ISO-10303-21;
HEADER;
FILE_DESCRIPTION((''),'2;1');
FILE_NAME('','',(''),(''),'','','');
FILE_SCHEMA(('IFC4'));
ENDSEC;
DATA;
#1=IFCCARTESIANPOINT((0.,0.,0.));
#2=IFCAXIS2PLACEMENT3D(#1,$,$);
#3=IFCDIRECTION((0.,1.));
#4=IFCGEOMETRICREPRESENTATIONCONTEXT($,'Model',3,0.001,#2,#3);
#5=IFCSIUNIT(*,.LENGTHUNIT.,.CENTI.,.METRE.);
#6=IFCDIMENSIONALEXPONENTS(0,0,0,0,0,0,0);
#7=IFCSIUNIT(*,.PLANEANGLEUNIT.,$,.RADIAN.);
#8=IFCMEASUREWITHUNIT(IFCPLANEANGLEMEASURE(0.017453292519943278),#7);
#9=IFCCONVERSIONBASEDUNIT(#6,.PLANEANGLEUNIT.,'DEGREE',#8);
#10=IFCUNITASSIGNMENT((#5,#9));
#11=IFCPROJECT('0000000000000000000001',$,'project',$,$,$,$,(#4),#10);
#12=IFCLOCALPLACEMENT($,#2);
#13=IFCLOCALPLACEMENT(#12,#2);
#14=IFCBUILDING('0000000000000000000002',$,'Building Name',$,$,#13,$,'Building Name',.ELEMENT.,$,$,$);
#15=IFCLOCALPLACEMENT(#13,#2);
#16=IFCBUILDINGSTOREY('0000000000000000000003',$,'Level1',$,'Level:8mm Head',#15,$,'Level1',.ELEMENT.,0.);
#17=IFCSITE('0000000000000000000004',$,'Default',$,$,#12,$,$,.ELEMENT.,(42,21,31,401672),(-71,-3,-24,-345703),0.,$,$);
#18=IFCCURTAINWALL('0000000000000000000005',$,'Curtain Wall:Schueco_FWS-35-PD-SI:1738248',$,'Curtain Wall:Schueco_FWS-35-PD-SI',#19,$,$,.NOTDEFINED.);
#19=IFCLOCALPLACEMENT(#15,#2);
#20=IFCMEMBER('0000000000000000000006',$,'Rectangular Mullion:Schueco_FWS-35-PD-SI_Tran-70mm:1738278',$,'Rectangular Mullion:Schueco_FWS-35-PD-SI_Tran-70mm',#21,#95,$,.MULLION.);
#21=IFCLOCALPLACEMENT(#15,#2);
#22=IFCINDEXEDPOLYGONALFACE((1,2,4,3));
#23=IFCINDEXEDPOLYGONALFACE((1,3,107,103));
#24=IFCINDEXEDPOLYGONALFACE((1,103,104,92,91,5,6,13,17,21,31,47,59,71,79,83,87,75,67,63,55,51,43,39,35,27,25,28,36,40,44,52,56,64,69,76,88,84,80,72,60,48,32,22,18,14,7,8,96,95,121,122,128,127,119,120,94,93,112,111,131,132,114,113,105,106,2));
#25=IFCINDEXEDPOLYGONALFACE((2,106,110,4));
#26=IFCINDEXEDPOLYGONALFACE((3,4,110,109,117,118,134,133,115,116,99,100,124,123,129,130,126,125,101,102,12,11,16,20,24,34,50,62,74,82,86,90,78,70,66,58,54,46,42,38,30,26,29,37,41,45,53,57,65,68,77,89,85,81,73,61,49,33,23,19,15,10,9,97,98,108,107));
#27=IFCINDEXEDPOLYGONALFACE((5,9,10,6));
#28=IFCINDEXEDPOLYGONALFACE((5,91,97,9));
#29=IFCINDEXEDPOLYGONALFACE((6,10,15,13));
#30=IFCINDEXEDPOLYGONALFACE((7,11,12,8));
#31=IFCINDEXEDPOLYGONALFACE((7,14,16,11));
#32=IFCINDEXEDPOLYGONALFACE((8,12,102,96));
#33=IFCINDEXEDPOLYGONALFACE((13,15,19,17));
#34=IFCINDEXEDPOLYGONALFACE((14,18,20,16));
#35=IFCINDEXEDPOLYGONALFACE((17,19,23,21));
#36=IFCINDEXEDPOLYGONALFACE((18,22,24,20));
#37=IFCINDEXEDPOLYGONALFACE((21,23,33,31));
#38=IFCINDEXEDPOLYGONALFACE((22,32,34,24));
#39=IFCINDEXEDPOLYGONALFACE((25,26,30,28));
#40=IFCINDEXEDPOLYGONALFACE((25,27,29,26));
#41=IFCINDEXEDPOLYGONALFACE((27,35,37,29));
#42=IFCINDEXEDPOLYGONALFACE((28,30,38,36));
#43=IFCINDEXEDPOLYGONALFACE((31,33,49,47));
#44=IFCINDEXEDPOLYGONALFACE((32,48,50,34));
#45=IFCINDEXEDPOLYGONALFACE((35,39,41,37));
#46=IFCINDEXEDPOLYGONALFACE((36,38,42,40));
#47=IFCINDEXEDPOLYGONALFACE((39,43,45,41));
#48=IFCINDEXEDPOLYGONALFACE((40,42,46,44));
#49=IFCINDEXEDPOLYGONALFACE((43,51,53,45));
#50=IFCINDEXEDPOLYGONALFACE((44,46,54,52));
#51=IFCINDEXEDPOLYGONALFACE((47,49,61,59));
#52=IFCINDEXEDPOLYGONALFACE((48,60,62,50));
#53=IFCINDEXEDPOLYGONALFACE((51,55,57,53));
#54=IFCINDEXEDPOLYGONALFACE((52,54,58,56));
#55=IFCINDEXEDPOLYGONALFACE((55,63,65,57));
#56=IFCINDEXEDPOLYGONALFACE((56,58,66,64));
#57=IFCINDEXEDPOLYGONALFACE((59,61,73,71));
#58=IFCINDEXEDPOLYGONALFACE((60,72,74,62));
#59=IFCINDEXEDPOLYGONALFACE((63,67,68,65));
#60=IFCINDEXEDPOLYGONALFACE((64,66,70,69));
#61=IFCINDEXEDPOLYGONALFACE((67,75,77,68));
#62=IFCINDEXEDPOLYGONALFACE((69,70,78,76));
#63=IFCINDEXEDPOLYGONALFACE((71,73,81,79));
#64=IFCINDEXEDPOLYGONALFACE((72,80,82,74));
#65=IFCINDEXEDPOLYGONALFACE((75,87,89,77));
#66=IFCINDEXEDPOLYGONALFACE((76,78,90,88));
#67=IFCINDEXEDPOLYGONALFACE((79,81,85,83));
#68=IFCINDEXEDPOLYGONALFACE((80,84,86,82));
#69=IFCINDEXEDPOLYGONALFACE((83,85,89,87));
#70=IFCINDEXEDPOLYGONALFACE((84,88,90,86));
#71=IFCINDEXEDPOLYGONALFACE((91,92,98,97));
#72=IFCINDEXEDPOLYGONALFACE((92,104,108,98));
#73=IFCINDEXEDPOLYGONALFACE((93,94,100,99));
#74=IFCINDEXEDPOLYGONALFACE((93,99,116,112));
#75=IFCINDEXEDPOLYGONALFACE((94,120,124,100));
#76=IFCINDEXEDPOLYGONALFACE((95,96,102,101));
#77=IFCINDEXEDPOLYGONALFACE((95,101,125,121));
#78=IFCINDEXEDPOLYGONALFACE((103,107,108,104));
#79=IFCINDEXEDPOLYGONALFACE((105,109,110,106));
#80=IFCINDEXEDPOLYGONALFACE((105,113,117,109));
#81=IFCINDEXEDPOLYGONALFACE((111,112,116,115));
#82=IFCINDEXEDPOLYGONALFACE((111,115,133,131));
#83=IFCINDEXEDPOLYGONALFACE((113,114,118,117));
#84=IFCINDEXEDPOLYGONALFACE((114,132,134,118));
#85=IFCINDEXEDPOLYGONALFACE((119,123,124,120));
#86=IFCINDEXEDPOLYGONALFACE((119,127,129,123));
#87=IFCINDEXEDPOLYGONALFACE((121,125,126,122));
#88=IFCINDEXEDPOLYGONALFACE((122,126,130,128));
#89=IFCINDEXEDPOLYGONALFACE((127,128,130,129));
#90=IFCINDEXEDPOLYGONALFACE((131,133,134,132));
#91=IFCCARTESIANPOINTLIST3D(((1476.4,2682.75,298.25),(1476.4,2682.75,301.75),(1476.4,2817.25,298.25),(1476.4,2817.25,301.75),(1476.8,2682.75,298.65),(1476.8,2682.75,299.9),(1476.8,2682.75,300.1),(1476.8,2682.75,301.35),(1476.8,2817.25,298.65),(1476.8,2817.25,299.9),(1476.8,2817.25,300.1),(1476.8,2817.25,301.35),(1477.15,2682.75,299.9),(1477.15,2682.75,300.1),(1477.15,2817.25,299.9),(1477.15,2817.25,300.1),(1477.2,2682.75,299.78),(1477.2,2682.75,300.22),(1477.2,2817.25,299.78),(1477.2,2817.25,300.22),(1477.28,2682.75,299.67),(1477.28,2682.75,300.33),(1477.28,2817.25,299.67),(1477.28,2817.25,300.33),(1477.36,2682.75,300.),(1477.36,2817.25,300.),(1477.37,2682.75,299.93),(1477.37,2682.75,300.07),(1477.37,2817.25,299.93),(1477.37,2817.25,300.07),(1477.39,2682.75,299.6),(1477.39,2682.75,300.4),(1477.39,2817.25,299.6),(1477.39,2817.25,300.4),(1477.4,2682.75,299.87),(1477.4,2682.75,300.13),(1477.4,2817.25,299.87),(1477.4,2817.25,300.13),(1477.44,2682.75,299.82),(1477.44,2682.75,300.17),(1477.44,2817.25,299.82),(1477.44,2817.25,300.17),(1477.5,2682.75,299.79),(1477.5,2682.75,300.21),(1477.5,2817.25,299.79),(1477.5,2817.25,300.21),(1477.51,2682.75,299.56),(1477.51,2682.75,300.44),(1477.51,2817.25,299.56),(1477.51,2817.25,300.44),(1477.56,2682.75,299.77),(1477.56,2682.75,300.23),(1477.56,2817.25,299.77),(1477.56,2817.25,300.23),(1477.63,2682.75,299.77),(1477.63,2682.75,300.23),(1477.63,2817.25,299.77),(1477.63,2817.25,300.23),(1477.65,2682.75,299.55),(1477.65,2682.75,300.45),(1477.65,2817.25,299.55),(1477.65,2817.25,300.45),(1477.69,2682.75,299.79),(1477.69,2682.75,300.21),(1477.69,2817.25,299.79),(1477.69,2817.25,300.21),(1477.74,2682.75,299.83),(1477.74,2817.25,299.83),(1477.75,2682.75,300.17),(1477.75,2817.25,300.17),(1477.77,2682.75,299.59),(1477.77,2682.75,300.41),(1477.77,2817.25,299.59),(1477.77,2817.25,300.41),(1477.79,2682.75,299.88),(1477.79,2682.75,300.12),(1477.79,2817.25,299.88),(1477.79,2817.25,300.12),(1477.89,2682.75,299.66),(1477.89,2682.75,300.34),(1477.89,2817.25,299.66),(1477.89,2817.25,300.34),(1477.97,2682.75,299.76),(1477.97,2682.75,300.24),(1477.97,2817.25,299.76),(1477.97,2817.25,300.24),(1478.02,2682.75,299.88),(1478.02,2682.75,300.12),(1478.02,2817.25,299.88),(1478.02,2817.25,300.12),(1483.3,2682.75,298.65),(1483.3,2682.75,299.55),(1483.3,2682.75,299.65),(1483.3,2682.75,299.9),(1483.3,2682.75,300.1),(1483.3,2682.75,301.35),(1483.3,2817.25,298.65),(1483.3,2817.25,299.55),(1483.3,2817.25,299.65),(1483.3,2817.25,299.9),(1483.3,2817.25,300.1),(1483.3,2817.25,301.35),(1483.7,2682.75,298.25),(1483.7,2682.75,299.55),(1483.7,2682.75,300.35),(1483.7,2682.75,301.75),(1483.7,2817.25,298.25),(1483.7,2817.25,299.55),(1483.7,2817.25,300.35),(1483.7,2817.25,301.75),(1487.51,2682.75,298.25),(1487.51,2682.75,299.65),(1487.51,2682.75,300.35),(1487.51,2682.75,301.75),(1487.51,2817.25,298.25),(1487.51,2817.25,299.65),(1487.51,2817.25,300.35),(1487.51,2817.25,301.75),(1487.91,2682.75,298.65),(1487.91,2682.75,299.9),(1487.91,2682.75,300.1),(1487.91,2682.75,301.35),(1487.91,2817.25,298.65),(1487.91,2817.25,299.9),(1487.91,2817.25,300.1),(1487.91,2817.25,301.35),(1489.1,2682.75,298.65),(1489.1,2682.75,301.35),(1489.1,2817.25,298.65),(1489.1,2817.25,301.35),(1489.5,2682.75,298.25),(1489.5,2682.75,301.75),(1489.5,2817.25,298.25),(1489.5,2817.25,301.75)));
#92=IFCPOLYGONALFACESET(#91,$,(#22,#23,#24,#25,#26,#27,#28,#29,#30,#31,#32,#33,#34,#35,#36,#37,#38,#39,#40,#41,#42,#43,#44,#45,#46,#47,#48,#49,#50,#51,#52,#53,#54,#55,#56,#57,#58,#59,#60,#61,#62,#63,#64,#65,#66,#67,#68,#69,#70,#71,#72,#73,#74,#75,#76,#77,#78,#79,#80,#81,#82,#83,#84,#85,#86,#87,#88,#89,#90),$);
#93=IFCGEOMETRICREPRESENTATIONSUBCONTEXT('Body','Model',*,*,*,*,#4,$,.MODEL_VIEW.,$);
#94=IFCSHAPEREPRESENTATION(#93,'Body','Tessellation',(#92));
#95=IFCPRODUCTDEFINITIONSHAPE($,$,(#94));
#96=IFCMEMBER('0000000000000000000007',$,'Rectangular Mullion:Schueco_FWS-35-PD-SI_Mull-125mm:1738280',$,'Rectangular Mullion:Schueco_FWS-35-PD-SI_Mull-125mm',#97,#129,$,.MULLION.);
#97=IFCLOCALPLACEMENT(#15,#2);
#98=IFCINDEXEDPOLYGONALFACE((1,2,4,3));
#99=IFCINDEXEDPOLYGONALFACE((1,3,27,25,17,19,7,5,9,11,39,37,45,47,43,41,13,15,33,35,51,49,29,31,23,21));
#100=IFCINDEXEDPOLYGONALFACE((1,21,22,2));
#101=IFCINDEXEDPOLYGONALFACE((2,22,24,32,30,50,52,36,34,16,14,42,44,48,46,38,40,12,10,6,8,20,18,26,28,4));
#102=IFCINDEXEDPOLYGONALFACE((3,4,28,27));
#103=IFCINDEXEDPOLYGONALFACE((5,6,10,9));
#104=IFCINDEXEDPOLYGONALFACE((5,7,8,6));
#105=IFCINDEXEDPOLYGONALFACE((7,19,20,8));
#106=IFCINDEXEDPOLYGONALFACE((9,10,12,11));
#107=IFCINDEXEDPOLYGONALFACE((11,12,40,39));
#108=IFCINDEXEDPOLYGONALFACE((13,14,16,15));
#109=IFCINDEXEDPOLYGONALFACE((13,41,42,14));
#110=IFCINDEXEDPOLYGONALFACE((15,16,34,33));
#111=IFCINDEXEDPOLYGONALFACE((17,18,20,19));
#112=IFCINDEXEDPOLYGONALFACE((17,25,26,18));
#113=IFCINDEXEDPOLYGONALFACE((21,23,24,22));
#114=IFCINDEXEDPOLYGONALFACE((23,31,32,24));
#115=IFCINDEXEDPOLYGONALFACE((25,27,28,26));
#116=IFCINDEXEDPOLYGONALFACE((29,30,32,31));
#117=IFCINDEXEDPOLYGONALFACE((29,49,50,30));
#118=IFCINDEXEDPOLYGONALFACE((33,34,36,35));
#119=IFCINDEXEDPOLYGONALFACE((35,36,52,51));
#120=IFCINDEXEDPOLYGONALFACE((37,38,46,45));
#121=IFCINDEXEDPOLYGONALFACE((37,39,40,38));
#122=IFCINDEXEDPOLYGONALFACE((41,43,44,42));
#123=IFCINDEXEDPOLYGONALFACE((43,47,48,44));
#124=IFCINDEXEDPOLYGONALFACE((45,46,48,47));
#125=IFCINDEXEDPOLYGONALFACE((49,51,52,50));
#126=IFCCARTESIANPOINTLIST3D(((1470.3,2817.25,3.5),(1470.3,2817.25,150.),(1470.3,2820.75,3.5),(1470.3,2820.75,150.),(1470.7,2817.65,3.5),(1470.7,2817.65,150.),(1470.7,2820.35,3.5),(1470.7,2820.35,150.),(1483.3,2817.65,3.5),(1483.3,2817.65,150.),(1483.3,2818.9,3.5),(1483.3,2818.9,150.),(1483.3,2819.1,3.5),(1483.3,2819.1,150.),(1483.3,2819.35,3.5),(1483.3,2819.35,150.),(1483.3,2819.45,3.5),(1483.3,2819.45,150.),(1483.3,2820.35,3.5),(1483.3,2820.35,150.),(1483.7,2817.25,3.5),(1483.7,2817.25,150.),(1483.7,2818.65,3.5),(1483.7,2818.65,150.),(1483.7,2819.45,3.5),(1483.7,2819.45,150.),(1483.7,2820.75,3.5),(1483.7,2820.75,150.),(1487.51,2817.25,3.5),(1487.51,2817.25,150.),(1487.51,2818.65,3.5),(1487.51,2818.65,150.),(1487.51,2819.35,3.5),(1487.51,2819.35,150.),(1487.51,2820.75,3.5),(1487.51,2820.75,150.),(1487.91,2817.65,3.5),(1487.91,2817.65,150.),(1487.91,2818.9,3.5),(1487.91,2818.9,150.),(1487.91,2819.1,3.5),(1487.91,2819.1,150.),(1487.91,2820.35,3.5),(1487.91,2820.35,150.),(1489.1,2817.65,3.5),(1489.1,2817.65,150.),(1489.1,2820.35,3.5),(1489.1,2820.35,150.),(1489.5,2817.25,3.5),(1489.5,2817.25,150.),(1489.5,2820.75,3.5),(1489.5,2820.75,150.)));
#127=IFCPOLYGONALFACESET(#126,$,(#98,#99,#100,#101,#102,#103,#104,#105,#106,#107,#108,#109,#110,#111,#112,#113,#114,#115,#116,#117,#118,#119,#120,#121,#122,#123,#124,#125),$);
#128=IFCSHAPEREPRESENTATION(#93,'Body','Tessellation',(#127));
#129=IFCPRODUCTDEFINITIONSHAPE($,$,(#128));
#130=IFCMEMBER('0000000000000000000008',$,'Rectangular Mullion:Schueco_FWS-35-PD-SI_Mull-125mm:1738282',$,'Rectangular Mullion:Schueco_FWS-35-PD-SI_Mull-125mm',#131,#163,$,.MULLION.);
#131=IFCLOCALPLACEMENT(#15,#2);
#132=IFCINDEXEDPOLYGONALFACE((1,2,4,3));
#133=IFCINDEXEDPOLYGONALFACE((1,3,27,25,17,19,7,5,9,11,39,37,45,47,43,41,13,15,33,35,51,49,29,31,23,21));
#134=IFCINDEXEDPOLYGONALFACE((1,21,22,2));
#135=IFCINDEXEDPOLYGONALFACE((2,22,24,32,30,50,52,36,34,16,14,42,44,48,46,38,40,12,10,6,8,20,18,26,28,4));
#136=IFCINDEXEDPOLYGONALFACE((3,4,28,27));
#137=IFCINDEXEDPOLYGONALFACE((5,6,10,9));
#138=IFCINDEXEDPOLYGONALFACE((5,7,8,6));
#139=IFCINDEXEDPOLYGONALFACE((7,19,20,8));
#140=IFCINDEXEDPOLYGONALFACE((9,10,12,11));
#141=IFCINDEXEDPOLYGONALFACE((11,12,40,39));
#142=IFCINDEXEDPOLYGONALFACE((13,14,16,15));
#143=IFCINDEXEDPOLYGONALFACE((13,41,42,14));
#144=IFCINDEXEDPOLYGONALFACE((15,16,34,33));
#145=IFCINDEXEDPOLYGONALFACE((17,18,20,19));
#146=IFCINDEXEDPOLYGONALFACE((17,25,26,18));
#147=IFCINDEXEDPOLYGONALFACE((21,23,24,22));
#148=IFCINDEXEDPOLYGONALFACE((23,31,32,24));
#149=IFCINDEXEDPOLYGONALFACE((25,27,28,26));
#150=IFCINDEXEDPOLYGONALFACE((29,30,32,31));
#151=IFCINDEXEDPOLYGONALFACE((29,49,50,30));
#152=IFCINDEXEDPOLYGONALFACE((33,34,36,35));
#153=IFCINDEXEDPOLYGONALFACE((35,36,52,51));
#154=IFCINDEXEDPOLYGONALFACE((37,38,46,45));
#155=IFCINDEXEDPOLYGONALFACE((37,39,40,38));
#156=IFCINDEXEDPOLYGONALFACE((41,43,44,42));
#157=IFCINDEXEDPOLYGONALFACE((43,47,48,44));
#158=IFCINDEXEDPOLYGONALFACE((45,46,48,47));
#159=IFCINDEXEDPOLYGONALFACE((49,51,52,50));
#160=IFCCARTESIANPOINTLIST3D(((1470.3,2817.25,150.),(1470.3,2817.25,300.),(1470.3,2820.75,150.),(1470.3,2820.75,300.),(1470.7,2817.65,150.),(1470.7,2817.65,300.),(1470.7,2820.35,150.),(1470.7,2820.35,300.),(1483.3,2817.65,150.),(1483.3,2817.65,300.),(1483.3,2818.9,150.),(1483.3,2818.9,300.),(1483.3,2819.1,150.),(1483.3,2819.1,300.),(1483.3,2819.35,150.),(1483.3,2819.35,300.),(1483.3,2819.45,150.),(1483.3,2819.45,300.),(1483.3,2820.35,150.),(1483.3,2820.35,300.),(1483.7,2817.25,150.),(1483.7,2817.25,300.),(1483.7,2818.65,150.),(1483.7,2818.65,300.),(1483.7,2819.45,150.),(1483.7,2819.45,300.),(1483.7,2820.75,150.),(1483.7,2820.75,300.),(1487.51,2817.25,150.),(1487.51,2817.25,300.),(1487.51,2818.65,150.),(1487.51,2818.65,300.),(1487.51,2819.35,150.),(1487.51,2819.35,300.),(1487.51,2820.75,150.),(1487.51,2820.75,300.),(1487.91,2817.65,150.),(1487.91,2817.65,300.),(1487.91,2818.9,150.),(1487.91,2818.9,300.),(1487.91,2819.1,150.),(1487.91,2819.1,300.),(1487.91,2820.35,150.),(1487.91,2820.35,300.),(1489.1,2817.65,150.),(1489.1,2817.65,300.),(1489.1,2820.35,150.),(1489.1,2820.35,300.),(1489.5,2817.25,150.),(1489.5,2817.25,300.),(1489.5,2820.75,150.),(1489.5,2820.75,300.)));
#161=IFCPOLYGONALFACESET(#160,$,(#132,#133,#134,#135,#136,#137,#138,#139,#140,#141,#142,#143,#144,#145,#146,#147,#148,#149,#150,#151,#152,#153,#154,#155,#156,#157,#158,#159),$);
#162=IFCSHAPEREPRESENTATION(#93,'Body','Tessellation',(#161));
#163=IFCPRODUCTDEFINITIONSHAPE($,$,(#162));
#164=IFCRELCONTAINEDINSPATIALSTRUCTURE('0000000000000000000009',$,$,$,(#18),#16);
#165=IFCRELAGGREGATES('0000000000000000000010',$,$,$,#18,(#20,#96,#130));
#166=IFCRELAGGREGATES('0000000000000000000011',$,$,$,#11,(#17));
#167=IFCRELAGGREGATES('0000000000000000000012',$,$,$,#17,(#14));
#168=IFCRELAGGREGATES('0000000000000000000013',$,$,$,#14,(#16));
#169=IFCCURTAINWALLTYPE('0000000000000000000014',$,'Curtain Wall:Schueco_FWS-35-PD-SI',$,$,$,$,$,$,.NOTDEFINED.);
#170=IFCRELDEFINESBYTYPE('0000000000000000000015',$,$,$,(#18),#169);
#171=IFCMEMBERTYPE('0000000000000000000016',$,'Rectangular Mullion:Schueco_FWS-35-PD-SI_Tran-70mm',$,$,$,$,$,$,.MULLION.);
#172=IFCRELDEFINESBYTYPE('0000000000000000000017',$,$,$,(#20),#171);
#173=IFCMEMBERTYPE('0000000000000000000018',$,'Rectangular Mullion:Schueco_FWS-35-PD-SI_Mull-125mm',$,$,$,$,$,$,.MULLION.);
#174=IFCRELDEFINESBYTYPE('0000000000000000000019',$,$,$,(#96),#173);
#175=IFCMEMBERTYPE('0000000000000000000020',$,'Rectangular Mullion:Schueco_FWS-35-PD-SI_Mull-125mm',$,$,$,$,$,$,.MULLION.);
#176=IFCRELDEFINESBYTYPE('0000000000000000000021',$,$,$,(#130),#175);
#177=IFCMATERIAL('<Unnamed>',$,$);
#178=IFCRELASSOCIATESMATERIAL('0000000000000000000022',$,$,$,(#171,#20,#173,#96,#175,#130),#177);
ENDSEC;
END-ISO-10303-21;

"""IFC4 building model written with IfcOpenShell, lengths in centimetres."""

from ifc_helpers import new_model, entity, si_unit, converted_unit, direction, frame, origin, place, context, subcontext, project, spatial, line, arc, indexed_curve, outline, extrude, source, transform, mapped, material, type_object, type_shapes, element, aggregate, save


model = new_model("IFC4")

# Units and contexts
model_context = context("Model", 3, precision=0.001, world=origin(), true_north=direction((0.0, 1.0)))
body_context = subcontext(model_context, "Body", "Model", "MODEL_VIEW")
ifc_project = project(units=[si_unit("LENGTHUNIT", "METRE", prefix="CENTI"), converted_unit("PLANEANGLEUNIT", "DEGREE", entity("IfcPlaneAngleMeasure", 0.017453292519943278), si_unit("PLANEANGLEUNIT", "RADIAN"), dimensions=[0, 0, 0, 0, 0, 0, 0])], contexts=[model_context])

# Site, building, storey
site_placement = place(None, origin())
site = spatial("IfcSite", under=ifc_project, at=site_placement, Name="Default", CompositionType="ELEMENT", RefLatitude=(42, 21, 31, 401672), RefLongitude=(-71, -3, -24, -345703), RefElevation=0.0)
building_placement = place(site_placement, origin())
building = spatial("IfcBuilding", under=site, at=building_placement, Name="Building Name", LongName="Building Name", CompositionType="ELEMENT")
storey_placement = place(building_placement, origin())
storey = spatial("IfcBuildingStorey", under=building, at=storey_placement, Name="Level1", ObjectType="Level:8mm Head", LongName="Level1", CompositionType="ELEMENT", Elevation=0.0)

# Curtain wall, members
curtain_wall_type = type_object("IfcCurtainWallType", Name="Curtain Wall:Schueco_FWS-35-PD-SI", PredefinedType="NOTDEFINED")
curtain_wall_placement = place(storey_placement, origin())
curtain_wall = element("IfcCurtainWall", 1, at=curtain_wall_placement, inside=storey, type_object=curtain_wall_type, Name="Curtain Wall:Schueco_FWS-35-PD-SI:1738248", ObjectType="Curtain Wall:Schueco_FWS-35-PD-SI", PredefinedType="NOTDEFINED")
ifc_material_1 = material(Name="<Unnamed>")
member_type_1 = type_object("IfcMemberType", Name="Rectangular Mullion:Schueco_FWS-35-PD-SI_Tran-70mm", PredefinedType="MULLION", material=ifc_material_1)
shared_shape_1 = source(origin(), body_context, "Body", "SweptSolid", [
    extrude(outline(indexed_curve([(-1.78, -6.52), (1.72, -6.52), (1.72, 0.78), (0.42, 0.78), (0.42, 0.38), (1.32, 0.38), (1.32, -6.12), (0.07, -6.12), (0.07, -5.77), (0.42, -5.34), (0.09, -4.9), (0.09, -5.14), (-0.03, -5.56), (-0.15, -5.14), (-0.15, -4.9), (-0.48, -5.34), (-0.13, -5.77), (-0.13, -6.12), (-1.38, -6.12), (-1.38, 0.38), (-0.13, 0.38), (-0.13, 4.99), (-1.38, 4.99), (-1.38, 6.18), (1.32, 6.18), (1.32, 4.99), (0.07, 4.99), (0.07, 0.38), (0.32, 0.38), (0.32, 4.59), (1.72, 4.59), (1.72, 6.58), (-1.78, 6.58), (-1.78, 4.59), (-0.38, 4.59), (-0.38, 0.78), (-1.78, 0.78)], segments=[line(1, 2, 3, 4, 5, 6, 7, 8, 9), arc(9, 10, 11), line(11, 12), arc(12, 13, 14), line(14, 15), arc(15, 16, 17), line(17, 18, 19, 20, 21, 22, 23, 24, 25, 26, 27, 28, 29, 30, 31, 32, 33, 34, 35, 36, 37, 1)], self_intersect=False)), frame((-0.03, 4.58, -134.5), z_axis=(0.0, 0.0, 1.0), x_axis=(-1.0, 0.0, 0.0)), (0.0, 0.0, 1.0), 134.5),
])
type_shapes(member_type_1, [shared_shape_1])
member_1_placement = place(curtain_wall_placement, frame((1487.5, 2682.75, 300.0), z_axis=(0.0, -1.0, 0.0), x_axis=(0.0, 0.0, 1.0)))
member_1 = element("IfcMember", 2, at=member_1_placement, type_object=member_type_1, material=ifc_material_1, Name="Rectangular Mullion:Schueco_FWS-35-PD-SI_Tran-70mm:1738278", ObjectType="Rectangular Mullion:Schueco_FWS-35-PD-SI_Tran-70mm", PredefinedType="MULLION", context=body_context, shape_type="MappedRepresentation", body=[
    mapped(shared_shape_1, transform((0.0, 0.0, 0.0), scale=1.0)),
])
member_type_2 = type_object("IfcMemberType", Name="Rectangular Mullion:Schueco_FWS-35-PD-SI_Mull-125mm", PredefinedType="MULLION", material=ifc_material_1)
shared_shape_2 = source(origin(), body_context, "Body", "SweptSolid", [
    extrude(outline(indexed_curve([(-1.78, -13.37), (1.72, -13.37), (1.72, 0.03), (0.42, 0.03), (0.42, -0.37), (1.32, -0.37), (1.32, -12.97), (-1.38, -12.97), (-1.38, -0.37), (-0.13, -0.37), (-0.13, 4.24), (-1.38, 4.24), (-1.38, 5.43), (1.32, 5.43), (1.32, 4.24), (0.07, 4.24), (0.07, -0.37), (0.32, -0.37), (0.32, 3.84), (1.72, 3.84), (1.72, 5.83), (-1.78, 5.83), (-1.78, 3.84), (-0.38, 3.84), (-0.38, 0.03), (-1.78, 0.03), (-1.78, -13.37)], self_intersect=False)), frame((-0.03, 3.83, -146.5), z_axis=(0.0, 0.0, 1.0), x_axis=(-1.0, 0.0, 0.0)), (0.0, 0.0, 1.0), 146.5),
])
type_shapes(member_type_2, [shared_shape_2])
member_2_placement = place(curtain_wall_placement, frame((1487.5, 2819.0, 3.5), z_axis=(0.0, 0.0, -1.0), x_axis=(0.0, -1.0, 0.0)))
member_2 = element("IfcMember", 3, at=member_2_placement, type_object=member_type_2, material=ifc_material_1, Name="Rectangular Mullion:Schueco_FWS-35-PD-SI_Mull-125mm:1738280", ObjectType="Rectangular Mullion:Schueco_FWS-35-PD-SI_Mull-125mm", PredefinedType="MULLION", context=body_context, shape_type="MappedRepresentation", body=[
    mapped(shared_shape_2, transform((0.0, 0.0, 0.0), scale=1.0)),
])
member_type_3 = type_object("IfcMemberType", Name="Rectangular Mullion:Schueco_FWS-35-PD-SI_Mull-125mm", PredefinedType="MULLION", material=ifc_material_1)
shared_shape_3 = source(origin(), body_context, "Body", "SweptSolid", [
    extrude(outline(indexed_curve([(-1.78, -13.37), (1.72, -13.37), (1.72, 0.03), (0.42, 0.03), (0.42, -0.37), (1.32, -0.37), (1.32, -12.97), (-1.38, -12.97), (-1.38, -0.37), (-0.13, -0.37), (-0.13, 4.24), (-1.38, 4.24), (-1.38, 5.43), (1.32, 5.43), (1.32, 4.24), (0.07, 4.24), (0.07, -0.37), (0.32, -0.37), (0.32, 3.84), (1.72, 3.84), (1.72, 5.83), (-1.78, 5.83), (-1.78, 3.84), (-0.38, 3.84), (-0.38, 0.03), (-1.78, 0.03), (-1.78, -13.37)], self_intersect=False)), frame((-0.03, 3.83, -150.0), z_axis=(0.0, 0.0, 1.0), x_axis=(-1.0, 0.0, 0.0)), (0.0, 0.0, 1.0), 150.0),
])
type_shapes(member_type_3, [shared_shape_3])
member_3_placement = place(curtain_wall_placement, frame((1487.5, 2819.0, 150.0), z_axis=(0.0, 0.0, -1.0), x_axis=(0.0, -1.0, 0.0)))
member_3 = element("IfcMember", 4, at=member_3_placement, type_object=member_type_3, material=ifc_material_1, Name="Rectangular Mullion:Schueco_FWS-35-PD-SI_Mull-125mm:1738282", ObjectType="Rectangular Mullion:Schueco_FWS-35-PD-SI_Mull-125mm", PredefinedType="MULLION", context=body_context, shape_type="MappedRepresentation", body=[
    mapped(shared_shape_3, transform((0.0, 0.0, 0.0), scale=1.0)),
])
aggregate(curtain_wall, [member_1, member_2, member_3])

save(model, "model.ifc")
